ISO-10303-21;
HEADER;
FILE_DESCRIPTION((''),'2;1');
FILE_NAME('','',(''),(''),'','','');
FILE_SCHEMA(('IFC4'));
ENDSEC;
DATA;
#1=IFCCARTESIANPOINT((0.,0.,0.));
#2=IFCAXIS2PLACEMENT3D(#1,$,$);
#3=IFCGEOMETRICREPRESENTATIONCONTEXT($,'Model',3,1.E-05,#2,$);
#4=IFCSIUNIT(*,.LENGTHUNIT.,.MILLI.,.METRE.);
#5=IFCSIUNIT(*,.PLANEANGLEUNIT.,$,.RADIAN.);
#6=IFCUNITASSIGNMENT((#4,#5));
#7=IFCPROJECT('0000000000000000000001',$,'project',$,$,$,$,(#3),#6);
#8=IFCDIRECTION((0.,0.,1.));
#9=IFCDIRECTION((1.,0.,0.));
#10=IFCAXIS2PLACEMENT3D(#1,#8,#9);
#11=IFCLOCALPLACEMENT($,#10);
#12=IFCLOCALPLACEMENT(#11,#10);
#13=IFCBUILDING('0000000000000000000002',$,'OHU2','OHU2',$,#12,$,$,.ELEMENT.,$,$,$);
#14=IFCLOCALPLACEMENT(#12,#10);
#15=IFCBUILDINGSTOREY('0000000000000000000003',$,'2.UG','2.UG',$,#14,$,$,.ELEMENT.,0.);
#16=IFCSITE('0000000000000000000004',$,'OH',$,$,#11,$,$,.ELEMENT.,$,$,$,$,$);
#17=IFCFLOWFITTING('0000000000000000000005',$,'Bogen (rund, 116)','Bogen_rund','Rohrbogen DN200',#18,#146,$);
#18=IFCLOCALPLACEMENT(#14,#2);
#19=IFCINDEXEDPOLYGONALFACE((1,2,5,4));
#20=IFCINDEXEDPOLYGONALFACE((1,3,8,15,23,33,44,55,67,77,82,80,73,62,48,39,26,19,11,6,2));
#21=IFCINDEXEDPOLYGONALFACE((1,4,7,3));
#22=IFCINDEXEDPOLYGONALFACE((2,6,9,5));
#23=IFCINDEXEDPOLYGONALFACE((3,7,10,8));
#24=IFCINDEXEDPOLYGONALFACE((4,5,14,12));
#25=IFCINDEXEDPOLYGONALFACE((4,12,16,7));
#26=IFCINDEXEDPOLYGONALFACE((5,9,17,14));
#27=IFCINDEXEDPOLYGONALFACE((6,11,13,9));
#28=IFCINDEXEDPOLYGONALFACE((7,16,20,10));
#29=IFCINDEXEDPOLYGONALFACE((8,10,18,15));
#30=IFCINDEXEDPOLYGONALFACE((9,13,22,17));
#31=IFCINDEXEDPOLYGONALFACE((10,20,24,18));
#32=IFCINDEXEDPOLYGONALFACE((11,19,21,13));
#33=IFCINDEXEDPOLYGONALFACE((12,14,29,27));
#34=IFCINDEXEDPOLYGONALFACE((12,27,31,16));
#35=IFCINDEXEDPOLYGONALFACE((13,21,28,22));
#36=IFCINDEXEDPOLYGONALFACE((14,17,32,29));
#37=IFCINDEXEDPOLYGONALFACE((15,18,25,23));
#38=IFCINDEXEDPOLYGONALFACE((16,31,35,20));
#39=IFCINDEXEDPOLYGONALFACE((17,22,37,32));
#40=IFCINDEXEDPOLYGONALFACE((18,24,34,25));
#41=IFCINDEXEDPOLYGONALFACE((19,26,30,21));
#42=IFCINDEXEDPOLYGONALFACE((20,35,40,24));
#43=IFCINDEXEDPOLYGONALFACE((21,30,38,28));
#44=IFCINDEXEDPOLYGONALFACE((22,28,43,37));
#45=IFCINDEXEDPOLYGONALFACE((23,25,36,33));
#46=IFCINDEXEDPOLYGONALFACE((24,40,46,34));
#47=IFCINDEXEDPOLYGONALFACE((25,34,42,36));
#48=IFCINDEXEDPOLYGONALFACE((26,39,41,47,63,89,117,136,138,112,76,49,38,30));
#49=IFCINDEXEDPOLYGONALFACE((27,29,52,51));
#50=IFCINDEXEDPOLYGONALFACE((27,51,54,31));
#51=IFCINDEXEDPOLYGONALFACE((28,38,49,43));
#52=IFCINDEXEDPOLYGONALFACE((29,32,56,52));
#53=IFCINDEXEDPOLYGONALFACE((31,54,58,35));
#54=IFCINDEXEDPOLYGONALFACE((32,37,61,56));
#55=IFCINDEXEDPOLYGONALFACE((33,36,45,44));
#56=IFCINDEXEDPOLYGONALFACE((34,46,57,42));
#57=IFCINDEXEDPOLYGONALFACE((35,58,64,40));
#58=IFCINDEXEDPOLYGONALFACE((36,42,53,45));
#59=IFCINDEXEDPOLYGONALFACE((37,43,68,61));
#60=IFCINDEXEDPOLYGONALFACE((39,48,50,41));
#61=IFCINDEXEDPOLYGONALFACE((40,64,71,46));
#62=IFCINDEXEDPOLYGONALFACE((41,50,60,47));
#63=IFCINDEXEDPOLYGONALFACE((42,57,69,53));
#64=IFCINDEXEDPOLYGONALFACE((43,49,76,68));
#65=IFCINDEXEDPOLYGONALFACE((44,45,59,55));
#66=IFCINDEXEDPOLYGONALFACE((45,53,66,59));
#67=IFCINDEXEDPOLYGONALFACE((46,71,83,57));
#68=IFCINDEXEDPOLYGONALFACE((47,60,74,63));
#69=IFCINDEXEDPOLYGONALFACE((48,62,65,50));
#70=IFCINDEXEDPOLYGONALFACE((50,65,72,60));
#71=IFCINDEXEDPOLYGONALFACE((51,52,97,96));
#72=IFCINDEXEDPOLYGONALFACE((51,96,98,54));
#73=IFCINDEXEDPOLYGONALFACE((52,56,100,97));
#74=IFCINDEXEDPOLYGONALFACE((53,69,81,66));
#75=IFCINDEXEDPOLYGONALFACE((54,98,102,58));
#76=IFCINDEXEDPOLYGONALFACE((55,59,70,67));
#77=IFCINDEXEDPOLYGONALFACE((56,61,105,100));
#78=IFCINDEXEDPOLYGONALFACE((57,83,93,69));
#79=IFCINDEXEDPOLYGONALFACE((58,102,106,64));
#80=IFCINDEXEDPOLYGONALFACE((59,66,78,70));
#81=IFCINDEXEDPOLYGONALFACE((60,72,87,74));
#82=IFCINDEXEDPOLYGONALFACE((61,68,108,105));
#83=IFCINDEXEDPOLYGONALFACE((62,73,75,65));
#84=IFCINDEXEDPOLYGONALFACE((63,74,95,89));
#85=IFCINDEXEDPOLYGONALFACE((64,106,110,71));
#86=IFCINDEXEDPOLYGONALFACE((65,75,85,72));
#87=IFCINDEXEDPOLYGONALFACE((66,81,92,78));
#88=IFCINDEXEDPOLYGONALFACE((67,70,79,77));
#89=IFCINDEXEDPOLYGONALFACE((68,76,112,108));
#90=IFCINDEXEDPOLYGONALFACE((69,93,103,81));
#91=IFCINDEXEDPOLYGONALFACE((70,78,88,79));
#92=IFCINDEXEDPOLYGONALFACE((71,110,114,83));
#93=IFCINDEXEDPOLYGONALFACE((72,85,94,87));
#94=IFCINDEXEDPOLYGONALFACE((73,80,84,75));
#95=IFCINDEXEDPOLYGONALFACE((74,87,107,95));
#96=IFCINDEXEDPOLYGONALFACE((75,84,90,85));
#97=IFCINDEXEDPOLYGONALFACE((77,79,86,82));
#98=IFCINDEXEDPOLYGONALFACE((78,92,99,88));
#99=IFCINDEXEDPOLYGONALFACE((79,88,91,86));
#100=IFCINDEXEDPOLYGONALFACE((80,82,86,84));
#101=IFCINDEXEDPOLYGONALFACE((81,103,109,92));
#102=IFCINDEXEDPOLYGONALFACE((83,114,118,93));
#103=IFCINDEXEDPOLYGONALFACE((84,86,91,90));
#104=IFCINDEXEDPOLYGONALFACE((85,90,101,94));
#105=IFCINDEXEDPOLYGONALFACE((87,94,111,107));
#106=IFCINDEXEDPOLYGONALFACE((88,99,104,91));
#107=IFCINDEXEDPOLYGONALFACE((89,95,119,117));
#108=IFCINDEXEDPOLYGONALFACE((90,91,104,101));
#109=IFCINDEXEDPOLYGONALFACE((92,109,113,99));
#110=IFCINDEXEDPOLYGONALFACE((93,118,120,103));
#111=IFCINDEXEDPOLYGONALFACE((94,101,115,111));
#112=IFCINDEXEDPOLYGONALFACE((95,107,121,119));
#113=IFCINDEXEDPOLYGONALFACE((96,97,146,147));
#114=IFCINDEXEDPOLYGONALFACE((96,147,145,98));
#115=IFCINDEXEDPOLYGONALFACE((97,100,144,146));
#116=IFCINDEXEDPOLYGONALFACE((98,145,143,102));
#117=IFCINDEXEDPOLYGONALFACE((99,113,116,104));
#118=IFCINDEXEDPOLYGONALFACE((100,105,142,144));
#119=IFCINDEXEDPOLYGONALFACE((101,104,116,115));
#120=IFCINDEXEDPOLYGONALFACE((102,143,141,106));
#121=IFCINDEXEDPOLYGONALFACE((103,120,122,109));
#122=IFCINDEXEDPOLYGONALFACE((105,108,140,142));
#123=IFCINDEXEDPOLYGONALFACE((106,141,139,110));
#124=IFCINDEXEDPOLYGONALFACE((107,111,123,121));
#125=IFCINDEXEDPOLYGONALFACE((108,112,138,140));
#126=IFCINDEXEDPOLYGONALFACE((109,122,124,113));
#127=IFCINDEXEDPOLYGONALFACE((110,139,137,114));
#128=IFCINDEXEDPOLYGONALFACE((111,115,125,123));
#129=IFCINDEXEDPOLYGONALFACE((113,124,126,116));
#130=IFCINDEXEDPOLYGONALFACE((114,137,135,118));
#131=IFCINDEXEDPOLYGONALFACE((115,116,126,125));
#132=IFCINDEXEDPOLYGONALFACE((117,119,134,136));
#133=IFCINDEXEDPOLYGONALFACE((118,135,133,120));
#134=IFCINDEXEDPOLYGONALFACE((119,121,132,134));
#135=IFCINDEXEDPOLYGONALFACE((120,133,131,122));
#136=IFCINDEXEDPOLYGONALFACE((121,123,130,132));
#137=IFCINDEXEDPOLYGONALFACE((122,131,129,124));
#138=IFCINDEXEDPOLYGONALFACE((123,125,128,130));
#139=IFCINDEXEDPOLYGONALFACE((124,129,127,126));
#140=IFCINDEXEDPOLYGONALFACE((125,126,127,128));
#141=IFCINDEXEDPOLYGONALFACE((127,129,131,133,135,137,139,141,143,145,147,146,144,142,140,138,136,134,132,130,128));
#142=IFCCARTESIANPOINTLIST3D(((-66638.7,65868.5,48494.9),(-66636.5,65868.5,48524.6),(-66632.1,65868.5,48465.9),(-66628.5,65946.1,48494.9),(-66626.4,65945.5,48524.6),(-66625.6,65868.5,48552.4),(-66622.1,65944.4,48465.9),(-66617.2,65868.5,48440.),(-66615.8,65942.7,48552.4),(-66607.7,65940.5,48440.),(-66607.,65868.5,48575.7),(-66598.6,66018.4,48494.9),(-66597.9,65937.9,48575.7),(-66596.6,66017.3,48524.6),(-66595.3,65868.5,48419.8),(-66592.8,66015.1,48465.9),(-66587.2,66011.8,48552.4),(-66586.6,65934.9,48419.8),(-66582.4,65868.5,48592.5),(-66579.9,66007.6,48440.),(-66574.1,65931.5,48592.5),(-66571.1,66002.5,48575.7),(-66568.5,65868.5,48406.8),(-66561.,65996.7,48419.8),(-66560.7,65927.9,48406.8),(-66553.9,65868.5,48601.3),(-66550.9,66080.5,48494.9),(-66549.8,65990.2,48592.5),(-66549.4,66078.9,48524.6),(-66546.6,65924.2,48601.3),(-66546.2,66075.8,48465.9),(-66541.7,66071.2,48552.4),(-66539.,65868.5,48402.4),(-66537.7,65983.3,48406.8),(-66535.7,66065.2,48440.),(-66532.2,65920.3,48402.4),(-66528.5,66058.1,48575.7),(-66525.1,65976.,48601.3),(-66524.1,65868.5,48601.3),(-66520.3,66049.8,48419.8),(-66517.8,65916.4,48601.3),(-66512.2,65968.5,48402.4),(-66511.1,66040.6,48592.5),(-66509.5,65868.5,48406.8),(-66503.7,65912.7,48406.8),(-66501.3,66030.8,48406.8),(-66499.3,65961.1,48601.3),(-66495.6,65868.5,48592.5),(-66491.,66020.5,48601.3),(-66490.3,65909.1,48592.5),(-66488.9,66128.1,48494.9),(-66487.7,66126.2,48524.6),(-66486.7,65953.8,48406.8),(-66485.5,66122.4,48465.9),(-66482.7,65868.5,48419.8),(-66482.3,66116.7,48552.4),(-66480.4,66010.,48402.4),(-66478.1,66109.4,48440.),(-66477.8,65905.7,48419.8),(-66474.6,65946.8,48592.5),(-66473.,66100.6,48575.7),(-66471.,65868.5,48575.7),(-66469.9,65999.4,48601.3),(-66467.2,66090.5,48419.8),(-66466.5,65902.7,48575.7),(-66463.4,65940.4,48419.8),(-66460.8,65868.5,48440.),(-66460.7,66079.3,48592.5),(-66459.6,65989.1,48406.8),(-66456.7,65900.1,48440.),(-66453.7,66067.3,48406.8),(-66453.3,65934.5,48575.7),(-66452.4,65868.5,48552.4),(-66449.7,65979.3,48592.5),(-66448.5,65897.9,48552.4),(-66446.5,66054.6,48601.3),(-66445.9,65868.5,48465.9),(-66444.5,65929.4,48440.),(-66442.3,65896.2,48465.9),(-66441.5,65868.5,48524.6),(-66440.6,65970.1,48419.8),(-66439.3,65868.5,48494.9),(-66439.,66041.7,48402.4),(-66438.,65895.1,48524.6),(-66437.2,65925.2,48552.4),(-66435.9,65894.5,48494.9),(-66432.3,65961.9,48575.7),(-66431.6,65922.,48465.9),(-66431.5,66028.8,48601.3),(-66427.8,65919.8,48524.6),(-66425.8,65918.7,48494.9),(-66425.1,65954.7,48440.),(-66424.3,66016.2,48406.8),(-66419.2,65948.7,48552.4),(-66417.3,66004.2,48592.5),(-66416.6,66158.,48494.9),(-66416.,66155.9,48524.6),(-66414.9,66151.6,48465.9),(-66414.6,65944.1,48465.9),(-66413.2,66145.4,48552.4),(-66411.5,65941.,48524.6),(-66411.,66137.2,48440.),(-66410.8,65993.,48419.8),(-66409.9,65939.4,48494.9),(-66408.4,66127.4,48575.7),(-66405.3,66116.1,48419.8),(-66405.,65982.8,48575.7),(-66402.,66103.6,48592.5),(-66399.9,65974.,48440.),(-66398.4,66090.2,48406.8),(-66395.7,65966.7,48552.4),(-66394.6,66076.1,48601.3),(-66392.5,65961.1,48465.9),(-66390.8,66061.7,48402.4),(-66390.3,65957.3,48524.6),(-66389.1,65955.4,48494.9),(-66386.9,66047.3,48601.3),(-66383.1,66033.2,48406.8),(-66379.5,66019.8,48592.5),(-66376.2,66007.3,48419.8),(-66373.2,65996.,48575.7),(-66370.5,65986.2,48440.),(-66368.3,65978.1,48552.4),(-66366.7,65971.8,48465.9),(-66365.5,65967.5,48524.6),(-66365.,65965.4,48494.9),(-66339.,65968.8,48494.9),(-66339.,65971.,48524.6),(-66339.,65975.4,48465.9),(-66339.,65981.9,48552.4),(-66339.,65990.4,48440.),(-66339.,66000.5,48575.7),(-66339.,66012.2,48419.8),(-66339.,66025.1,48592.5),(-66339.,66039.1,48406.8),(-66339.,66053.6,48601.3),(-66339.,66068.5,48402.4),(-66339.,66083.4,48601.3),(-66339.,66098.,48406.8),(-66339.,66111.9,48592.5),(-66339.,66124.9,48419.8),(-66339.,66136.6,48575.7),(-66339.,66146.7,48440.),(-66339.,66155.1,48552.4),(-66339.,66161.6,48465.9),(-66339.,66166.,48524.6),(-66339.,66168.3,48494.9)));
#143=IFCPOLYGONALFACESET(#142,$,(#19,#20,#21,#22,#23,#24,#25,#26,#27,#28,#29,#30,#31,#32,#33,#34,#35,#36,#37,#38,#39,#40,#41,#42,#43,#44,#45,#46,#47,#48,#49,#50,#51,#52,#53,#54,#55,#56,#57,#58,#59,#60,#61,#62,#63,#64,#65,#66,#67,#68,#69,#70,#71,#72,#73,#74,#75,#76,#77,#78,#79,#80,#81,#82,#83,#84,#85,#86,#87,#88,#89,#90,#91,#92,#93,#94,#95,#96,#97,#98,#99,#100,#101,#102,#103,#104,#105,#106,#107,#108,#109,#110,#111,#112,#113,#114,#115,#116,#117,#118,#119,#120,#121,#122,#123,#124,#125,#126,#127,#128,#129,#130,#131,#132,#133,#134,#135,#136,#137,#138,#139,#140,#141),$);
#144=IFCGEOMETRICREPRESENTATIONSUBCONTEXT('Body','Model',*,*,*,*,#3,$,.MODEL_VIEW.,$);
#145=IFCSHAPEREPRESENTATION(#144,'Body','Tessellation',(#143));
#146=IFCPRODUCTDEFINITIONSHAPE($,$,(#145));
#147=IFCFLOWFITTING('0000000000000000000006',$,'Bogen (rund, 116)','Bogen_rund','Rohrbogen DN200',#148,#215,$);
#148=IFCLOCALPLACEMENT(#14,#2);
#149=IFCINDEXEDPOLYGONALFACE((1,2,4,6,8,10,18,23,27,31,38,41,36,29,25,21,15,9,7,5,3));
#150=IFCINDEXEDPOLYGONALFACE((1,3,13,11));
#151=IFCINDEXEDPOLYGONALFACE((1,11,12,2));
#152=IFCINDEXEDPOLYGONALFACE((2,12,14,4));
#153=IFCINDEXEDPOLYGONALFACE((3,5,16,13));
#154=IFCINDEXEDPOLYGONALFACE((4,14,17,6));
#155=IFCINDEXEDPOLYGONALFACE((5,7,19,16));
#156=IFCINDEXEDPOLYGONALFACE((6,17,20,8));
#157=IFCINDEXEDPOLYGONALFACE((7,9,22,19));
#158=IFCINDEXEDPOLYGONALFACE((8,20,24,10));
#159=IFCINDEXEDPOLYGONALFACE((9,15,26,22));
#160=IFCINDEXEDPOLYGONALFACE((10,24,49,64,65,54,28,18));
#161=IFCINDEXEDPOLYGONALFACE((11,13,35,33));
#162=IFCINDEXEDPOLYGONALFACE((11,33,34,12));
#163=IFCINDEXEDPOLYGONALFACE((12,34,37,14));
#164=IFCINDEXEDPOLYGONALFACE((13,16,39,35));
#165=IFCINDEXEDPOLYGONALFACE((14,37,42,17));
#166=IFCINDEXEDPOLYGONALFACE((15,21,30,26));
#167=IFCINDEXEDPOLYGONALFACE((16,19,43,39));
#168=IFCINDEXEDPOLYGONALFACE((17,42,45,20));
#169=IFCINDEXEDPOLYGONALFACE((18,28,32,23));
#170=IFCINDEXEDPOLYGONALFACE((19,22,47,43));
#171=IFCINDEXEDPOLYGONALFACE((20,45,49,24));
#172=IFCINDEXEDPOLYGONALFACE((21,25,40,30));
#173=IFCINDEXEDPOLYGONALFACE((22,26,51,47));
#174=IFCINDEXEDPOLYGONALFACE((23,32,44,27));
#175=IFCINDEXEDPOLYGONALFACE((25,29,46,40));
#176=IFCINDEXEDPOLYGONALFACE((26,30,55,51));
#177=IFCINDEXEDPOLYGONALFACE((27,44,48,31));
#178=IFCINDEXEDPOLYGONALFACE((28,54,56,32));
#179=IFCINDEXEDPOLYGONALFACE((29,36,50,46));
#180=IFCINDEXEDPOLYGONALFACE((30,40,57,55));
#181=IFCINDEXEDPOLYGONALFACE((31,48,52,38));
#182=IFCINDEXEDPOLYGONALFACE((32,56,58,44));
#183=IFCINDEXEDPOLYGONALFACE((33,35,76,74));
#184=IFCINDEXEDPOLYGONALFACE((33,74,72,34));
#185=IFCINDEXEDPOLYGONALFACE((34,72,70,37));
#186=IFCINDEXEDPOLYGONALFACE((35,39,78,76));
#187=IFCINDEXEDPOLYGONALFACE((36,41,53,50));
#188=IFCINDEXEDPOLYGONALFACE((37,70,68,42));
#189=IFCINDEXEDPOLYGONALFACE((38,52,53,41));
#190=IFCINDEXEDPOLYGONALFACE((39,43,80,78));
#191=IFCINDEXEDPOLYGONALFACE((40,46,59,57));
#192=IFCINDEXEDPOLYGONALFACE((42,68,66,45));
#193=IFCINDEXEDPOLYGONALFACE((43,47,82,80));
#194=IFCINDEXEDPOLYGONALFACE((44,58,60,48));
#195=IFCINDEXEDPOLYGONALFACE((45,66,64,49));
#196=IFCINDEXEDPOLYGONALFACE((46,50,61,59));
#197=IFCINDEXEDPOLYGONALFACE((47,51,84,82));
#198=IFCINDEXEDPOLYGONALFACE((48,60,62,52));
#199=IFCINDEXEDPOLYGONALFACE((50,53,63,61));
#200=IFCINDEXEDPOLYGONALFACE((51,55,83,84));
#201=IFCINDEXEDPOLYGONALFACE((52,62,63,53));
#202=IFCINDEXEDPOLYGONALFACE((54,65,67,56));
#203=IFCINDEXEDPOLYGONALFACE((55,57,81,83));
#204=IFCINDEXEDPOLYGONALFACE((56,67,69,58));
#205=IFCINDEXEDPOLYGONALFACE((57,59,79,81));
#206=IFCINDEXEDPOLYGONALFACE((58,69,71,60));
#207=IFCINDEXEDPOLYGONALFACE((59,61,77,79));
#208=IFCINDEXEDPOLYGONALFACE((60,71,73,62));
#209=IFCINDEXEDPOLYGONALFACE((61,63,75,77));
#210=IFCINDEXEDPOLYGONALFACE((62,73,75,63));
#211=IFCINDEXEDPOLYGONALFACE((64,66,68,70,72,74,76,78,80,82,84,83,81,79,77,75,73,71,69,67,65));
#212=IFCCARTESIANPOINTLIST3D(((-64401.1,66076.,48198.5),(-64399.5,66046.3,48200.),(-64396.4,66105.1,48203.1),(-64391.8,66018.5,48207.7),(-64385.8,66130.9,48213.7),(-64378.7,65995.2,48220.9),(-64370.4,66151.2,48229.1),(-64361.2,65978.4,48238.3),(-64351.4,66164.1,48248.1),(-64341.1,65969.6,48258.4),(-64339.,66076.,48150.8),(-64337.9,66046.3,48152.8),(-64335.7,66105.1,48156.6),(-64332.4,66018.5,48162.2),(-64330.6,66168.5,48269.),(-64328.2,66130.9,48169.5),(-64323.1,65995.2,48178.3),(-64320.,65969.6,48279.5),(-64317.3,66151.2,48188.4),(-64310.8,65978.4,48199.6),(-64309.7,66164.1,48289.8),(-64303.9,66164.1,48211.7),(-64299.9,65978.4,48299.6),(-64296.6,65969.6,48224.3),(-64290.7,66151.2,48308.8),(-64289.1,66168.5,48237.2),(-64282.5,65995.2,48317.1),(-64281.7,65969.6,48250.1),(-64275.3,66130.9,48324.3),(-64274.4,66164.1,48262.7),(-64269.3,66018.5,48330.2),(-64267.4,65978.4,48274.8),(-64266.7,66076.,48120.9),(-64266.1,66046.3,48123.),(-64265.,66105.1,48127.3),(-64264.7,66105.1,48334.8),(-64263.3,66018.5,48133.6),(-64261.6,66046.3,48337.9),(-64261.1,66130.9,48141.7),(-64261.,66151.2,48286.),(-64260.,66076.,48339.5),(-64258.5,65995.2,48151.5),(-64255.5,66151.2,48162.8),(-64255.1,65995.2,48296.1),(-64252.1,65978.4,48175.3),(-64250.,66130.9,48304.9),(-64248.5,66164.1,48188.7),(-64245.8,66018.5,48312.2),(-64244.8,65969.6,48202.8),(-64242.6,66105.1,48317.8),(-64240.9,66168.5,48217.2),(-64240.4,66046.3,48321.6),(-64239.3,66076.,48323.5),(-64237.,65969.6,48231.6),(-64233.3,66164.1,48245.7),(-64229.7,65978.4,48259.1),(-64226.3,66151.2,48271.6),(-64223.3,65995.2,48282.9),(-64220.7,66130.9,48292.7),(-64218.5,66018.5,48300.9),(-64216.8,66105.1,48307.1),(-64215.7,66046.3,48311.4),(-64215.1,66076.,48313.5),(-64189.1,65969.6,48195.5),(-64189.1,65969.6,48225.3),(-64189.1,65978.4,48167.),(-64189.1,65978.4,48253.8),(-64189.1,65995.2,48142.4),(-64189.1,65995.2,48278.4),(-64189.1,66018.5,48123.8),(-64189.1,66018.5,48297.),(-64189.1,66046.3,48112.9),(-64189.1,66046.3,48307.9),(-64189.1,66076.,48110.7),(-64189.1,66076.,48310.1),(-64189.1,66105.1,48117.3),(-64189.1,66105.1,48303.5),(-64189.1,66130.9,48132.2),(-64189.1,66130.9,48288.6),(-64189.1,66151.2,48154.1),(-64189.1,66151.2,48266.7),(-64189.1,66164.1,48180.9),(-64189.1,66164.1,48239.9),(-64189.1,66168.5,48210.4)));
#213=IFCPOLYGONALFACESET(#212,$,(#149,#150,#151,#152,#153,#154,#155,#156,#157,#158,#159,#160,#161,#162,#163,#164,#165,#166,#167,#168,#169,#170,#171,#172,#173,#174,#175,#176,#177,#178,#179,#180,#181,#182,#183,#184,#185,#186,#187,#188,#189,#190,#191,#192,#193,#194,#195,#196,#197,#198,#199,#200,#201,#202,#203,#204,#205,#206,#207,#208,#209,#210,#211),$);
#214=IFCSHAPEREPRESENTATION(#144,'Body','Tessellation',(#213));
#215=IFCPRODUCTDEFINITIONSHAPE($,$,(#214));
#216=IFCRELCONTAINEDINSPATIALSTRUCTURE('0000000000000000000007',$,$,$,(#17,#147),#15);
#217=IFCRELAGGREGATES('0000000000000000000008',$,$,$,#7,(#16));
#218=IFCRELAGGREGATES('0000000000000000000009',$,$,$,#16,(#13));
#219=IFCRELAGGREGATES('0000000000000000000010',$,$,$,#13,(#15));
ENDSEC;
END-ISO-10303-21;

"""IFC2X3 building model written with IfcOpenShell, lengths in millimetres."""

from ifc_helpers import new_model, entity, si_unit, frame, origin, origin_with_axes, place, context, subcontext, project, spatial, element, save


model = new_model("IFC2X3")

# Units and contexts
model_context = context("Model", 3, precision=1e-05, world=origin())
body_context = subcontext(model_context, "Body", "Model", "MODEL_VIEW")
ifc_project = project(units=[si_unit("LENGTHUNIT", "METRE", prefix="MILLI"), si_unit("PLANEANGLEUNIT", "RADIAN")], contexts=[model_context])

# Site, building, storey
site_placement = place(None, origin_with_axes())
site = spatial("IfcSite", under=ifc_project, at=site_placement, Name="OH", CompositionType="ELEMENT")
building_placement = place(site_placement, origin_with_axes())
building = spatial("IfcBuilding", under=site, at=building_placement, Name="OHU2", Description="OHU2", CompositionType="ELEMENT")
storey_placement = place(building_placement, origin_with_axes())
storey = spatial("IfcBuildingStorey", under=building, at=storey_placement, Name="2.UG", Description="2.UG", CompositionType="ELEMENT", Elevation=0.0)

# Flow fittings
flow_fitting_1_placement = place(storey_placement, frame((-66489.0, 66018.5, 48502.4), z_axis=(0.0, 0.0, 1.0), x_axis=(1.0, 0.0, 0.0)))
element("IfcFlowFitting", 1, at=flow_fitting_1_placement, inside=storey, Name="Bogen (rund, 116)", Description="Bogen_rund", ObjectType="Rohrbogen DN200", context=body_context, shape_type="SweptSolid", body=[
    entity("IfcRevolvedAreaSolid", entity("IfcCircleProfileDef", "AREA", None, entity("IfcAxis2Placement2D", entity("IfcCartesianPoint", [0.0, 0.0]), entity("IfcDirection", [1.0, 0.0])), 100.0), entity("IfcAxis2Placement3D", entity("IfcCartesianPoint", [150.0, 50.0, 0.0]), entity("IfcDirection", [-1.0, 0.000003, 0.0]), entity("IfcDirection", [0.0, 0.0, -1.0])), entity("IfcAxis1Placement", entity("IfcCartesianPoint", [0.0, 200.0, 0.0]), entity("IfcDirection", [-1.0, 0.0, 0.0])), 1.570796),
])
flow_fitting_2_placement = place(storey_placement, frame((-64250.2, 66068.5, 48209.3), z_axis=(0.0, 0.0, 1.0), x_axis=(1.0, 0.0, 0.0)))
element("IfcFlowFitting", 2, at=flow_fitting_2_placement, inside=storey, Name="Bogen (rund, 116)", Description="Bogen_rund", ObjectType="Rohrbogen DN200", context=body_context, shape_type="SweptSolid", body=[
    entity("IfcRevolvedAreaSolid", entity("IfcCircleProfileDef", "AREA", None, entity("IfcAxis2Placement2D", entity("IfcCartesianPoint", [0.0, 0.0]), entity("IfcDirection", [1.0, 0.0])), 100.0), entity("IfcAxis2Placement3D", entity("IfcCartesianPoint", [-80.4, 0.0, 59.6]), entity("IfcDirection", [0.707107, 0.0, -0.707107]), entity("IfcDirection", [0.0, 1.0, 0.0])), entity("IfcAxis1Placement", entity("IfcCartesianPoint", [0.0, 200.0, 0.0]), entity("IfcDirection", [-1.0, 0.0, 0.0])), 0.785398),
])

save(model, "model.ifc")
